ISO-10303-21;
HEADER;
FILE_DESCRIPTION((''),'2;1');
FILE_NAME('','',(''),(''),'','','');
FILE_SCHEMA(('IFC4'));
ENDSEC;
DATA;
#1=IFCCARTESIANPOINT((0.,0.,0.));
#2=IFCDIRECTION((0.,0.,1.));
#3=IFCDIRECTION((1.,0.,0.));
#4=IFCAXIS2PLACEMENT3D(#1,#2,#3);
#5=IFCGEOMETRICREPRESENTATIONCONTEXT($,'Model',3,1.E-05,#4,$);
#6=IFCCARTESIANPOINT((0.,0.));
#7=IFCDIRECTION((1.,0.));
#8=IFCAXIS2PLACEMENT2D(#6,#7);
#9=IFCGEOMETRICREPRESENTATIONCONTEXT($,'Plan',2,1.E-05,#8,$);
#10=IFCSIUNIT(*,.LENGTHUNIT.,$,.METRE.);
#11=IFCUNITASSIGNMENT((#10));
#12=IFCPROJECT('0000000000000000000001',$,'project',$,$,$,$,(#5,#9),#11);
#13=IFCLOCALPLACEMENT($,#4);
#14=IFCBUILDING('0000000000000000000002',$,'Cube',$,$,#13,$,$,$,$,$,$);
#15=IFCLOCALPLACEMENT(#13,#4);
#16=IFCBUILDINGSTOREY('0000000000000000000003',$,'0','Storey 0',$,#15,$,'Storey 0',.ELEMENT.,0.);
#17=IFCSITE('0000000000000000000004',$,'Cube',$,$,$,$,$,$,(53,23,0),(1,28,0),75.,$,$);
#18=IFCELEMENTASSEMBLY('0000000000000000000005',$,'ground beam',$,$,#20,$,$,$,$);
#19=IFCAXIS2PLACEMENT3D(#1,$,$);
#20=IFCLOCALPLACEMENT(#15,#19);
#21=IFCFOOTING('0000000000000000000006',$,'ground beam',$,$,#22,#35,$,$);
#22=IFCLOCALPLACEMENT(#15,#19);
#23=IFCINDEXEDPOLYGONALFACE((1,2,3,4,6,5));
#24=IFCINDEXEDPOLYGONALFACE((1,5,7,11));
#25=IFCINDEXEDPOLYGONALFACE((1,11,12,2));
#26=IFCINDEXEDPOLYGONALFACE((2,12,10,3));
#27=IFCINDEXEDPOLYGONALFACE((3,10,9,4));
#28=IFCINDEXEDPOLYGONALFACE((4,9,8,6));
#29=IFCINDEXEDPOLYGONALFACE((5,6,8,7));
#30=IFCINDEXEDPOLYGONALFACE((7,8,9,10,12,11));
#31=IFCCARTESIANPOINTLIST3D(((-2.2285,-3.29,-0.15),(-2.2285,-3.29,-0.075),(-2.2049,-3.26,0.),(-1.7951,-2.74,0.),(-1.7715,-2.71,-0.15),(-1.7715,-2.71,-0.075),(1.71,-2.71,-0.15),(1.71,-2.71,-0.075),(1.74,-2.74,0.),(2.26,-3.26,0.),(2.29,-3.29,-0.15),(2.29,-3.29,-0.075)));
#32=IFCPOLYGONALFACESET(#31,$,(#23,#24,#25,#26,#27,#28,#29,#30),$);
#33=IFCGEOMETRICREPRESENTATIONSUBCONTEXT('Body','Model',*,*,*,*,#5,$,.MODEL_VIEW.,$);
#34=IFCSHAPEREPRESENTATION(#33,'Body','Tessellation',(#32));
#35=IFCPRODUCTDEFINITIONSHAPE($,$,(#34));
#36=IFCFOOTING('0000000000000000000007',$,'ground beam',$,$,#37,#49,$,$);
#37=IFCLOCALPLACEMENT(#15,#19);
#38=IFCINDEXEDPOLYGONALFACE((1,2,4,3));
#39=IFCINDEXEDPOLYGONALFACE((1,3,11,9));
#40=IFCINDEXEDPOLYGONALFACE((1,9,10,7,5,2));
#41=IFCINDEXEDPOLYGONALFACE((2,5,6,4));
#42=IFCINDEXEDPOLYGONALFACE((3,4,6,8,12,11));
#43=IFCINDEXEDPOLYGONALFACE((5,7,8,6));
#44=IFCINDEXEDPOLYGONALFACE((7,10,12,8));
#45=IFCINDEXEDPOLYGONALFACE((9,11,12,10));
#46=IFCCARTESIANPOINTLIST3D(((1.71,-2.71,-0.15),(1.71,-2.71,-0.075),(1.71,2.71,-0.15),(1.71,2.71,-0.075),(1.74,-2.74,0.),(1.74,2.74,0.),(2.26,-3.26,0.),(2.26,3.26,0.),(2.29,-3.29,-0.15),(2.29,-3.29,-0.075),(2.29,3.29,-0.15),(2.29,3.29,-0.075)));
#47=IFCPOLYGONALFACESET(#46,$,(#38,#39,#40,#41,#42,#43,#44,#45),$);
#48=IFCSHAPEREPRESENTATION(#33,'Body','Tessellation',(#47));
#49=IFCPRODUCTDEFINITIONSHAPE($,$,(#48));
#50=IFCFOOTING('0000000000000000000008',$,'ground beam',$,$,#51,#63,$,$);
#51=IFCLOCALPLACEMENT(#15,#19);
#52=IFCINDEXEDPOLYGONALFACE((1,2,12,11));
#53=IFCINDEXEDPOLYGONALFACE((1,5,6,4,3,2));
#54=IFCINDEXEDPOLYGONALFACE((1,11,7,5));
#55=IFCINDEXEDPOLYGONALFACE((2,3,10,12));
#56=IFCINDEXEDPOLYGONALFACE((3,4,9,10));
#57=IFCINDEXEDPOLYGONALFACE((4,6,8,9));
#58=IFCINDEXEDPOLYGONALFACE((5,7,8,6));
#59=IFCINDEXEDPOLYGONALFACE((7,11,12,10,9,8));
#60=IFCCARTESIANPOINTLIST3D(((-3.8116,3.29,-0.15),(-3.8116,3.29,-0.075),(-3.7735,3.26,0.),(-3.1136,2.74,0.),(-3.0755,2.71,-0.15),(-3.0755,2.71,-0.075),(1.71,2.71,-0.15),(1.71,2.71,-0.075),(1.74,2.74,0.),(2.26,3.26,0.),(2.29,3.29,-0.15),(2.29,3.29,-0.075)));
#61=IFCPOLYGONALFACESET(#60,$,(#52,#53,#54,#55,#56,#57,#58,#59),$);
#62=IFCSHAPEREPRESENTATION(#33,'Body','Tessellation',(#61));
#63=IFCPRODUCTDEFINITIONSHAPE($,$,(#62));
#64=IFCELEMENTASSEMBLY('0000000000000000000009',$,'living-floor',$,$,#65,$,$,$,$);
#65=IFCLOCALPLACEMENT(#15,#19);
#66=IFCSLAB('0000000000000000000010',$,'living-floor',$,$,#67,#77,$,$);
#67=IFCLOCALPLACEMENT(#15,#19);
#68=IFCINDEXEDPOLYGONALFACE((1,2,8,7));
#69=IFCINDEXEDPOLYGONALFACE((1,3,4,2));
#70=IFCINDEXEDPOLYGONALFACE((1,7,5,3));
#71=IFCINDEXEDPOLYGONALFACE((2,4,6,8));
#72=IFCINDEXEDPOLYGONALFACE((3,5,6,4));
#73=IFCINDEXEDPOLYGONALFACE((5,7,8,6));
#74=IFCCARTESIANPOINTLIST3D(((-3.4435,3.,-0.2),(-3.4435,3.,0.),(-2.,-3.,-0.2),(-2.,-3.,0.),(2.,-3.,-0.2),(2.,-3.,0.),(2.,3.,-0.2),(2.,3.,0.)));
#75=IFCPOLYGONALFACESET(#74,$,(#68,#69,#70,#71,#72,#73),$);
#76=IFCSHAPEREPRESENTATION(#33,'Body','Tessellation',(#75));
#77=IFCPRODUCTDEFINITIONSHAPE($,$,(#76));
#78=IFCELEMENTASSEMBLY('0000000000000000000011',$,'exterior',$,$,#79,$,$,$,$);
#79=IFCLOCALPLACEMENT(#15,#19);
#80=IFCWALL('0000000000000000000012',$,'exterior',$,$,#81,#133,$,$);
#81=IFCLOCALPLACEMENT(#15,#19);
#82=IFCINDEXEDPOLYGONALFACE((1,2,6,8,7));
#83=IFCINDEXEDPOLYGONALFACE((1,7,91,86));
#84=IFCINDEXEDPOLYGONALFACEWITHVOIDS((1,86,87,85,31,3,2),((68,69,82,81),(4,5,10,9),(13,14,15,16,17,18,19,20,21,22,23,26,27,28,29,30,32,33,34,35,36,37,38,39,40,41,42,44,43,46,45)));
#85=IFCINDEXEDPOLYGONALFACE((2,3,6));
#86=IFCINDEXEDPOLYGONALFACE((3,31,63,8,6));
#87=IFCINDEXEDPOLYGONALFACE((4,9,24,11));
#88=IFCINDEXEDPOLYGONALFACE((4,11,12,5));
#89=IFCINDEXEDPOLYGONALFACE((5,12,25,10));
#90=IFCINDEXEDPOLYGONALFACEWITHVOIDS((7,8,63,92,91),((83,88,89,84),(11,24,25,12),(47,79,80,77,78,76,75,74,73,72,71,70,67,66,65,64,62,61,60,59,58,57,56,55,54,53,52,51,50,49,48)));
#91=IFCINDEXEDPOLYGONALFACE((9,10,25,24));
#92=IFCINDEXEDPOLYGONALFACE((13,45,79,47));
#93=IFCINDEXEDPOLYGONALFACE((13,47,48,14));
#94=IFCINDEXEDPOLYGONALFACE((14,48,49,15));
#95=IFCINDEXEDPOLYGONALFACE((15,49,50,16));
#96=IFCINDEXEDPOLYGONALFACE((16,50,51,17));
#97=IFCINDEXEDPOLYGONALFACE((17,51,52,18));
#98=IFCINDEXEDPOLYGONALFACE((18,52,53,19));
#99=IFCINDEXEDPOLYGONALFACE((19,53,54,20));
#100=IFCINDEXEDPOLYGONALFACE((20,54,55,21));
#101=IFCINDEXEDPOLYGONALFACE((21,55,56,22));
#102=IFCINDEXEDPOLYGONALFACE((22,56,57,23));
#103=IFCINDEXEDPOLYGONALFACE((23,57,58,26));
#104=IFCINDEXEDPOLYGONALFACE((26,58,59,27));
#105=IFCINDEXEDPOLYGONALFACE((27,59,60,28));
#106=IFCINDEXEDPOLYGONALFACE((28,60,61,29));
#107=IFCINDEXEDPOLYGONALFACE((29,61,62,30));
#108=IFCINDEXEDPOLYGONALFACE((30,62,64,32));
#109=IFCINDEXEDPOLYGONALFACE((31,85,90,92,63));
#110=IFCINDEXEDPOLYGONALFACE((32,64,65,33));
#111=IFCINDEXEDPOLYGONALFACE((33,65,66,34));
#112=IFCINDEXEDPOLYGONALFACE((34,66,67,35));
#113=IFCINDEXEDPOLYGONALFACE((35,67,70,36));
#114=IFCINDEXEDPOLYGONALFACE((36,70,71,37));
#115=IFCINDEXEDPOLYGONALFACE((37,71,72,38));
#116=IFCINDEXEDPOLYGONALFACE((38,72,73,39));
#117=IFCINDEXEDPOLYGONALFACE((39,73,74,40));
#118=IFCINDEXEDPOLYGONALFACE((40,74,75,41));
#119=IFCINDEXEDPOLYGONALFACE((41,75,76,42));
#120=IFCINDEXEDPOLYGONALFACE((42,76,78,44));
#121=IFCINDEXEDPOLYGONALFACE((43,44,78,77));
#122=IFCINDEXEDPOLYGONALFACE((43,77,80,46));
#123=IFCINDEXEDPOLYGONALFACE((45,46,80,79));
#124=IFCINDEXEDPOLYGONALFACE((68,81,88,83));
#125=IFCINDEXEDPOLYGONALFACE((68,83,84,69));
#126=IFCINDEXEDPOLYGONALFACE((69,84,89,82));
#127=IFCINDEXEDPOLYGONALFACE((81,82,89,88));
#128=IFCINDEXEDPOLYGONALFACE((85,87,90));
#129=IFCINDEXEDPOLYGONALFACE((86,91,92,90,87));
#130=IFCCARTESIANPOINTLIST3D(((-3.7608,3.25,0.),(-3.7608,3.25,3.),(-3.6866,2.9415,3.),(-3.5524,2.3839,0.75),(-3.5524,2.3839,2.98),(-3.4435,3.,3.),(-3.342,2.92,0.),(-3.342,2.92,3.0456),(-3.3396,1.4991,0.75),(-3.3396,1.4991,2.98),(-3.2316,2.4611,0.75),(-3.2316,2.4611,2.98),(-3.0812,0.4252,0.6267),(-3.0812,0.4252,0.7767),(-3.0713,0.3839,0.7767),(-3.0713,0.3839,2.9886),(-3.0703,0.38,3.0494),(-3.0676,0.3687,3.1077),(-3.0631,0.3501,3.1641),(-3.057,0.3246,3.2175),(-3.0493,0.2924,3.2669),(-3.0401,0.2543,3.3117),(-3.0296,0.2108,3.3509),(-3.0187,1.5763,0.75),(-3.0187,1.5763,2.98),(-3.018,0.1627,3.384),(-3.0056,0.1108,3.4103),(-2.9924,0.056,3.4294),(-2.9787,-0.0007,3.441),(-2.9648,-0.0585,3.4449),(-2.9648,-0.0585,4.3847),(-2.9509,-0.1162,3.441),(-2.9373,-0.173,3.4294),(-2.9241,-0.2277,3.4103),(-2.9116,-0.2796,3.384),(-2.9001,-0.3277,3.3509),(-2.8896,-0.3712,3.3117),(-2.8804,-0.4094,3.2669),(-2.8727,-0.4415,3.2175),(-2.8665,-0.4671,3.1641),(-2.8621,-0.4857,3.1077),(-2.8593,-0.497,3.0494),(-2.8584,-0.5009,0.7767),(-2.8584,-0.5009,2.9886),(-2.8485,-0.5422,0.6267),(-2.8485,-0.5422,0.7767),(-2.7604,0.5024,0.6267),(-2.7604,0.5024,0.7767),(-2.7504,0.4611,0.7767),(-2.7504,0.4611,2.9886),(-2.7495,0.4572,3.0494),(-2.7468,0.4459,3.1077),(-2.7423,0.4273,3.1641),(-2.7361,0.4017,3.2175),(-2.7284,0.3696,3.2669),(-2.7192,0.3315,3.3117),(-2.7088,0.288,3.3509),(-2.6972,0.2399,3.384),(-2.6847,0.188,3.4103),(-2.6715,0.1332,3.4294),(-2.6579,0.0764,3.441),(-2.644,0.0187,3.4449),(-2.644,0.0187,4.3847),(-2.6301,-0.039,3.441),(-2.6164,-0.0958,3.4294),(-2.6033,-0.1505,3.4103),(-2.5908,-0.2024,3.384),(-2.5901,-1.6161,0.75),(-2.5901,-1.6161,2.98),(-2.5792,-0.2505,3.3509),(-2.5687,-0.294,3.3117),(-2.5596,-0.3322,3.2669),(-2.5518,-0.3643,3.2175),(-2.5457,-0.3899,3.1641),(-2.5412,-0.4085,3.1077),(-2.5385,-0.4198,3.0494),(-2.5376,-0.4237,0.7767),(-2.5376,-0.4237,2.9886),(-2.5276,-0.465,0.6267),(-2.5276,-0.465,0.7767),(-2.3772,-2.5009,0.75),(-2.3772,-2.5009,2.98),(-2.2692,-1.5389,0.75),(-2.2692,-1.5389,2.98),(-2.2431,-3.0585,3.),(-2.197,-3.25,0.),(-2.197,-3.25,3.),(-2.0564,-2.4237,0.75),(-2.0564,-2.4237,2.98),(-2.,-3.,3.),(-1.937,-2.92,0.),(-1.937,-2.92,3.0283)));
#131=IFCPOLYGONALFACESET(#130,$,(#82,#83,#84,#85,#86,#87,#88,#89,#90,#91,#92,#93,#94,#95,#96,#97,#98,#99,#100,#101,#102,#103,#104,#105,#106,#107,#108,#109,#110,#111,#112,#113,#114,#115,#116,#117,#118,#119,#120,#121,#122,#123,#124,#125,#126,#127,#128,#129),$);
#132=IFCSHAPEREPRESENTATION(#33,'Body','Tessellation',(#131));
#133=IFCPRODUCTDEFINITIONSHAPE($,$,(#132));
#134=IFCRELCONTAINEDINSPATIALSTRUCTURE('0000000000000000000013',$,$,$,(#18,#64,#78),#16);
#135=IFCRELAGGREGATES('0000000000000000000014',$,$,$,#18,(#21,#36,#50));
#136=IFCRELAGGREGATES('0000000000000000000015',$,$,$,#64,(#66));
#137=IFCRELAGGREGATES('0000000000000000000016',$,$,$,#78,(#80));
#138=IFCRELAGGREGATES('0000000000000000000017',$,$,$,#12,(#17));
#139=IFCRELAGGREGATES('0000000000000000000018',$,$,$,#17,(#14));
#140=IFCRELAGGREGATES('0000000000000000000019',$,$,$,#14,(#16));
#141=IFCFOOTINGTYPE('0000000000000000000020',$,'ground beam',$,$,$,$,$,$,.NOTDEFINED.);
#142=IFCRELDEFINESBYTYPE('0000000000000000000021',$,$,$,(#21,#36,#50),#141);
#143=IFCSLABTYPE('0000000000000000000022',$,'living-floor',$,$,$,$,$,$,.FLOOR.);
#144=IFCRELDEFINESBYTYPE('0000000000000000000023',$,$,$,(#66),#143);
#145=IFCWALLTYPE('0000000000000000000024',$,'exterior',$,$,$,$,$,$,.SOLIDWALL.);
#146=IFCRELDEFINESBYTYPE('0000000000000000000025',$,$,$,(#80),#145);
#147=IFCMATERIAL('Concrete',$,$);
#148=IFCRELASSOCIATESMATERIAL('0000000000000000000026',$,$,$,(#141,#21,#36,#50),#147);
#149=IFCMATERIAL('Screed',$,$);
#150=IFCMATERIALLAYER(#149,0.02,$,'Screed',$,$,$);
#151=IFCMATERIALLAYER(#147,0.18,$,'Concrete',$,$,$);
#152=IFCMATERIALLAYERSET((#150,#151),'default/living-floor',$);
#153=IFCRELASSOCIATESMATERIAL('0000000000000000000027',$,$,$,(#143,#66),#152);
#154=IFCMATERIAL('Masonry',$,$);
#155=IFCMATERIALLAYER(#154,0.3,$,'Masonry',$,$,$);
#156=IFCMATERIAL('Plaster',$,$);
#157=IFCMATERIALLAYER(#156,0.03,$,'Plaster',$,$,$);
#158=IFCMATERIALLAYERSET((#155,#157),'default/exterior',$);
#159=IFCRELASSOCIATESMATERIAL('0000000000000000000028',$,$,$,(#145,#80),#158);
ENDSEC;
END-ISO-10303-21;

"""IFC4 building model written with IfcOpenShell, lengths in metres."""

from ifc_helpers import new_model, si_unit, frame, origin, origin_with_axes, origin_2d_with_axis, place, context, subcontext, project, spatial, polyline, outline, extrude, clip, halfspace, bounded_halfspace, material, layer, layer_set, layer_usage, material_profile, profile_set, profile_usage, type_object, element, aggregate, save


model = new_model("IFC4")

# Units and contexts
model_context = context("Model", 3, precision=1e-05, world=origin_with_axes())
plan_context = context("Plan", 2, precision=1e-05, world=origin_2d_with_axis())
body_context_1 = subcontext(model_context, "Body", "Model", "MODEL_VIEW")
ifc_project = project(units=[si_unit("LENGTHUNIT", "METRE")], contexts=[model_context, plan_context])

# Site, building, storey
site = spatial("IfcSite", under=ifc_project, Name="Cube", RefLatitude=(53, 23, 0), RefLongitude=(1, 28, 0), RefElevation=75.0)
building_placement = place(None, origin_with_axes())
building = spatial("IfcBuilding", under=site, at=building_placement, Name="Cube")
storey_placement = place(building_placement, origin_with_axes())
storey = spatial("IfcBuildingStorey", under=building, at=storey_placement, Name="0", Description="Storey 0", LongName="Storey 0", CompositionType="ELEMENT", Elevation=0.0)

# Element assembly, footings
assembly_1_placement = place(storey_placement, origin_with_axes())
assembly_1 = element("IfcElementAssembly", 1, at=assembly_1_placement, inside=storey, Name="ground beam")
ifc_material_1 = material(Name="Concrete")
ifc_material_profile = material_profile(ifc_material_1, outline(polyline([(-0.26, 0.0), (-0.29, -0.075), (-0.29, -0.15), (0.29, -0.15), (0.29, -0.075), (0.26, 0.0), (-0.26, 0.0)])))
ifc_profile_set = profile_set([ifc_material_profile])
ifc_profile_usage_1 = profile_usage(ifc_profile_set)
footing_type = type_object("IfcFootingType", Name="ground beam", PredefinedType="NOTDEFINED", material=ifc_profile_set)
footing_1_placement = place(assembly_1_placement, frame((3.0, -3.0, 0.0), z_axis=(-1.0, 0.0, 0.0), x_axis=(0.0, -1.0, 0.0)))
footing_1 = element("IfcFooting", 2, at=footing_1_placement, type_object=footing_type, material=ifc_profile_usage_1, Name="ground beam", context=body_context_1, shape_type="Clipping", body=[
    clip(clip(extrude(outline(polyline([(-0.26, 0.0), (-0.29, -0.075), (-0.29, -0.15), (0.29, -0.15), (0.29, -0.075), (0.26, 0.0), (-0.26, 0.0)])), origin_with_axes(), (0.0, 0.0, 1.0), 6.0), halfspace(frame((0.0, 0.0, 1.0), z_axis=(-0.707107, 0.0, -0.707107), x_axis=(0.0, 1.0, 0.0)), False)), halfspace(frame((0.0, 0.0, 5.0), z_axis=(-0.618904, 0.0, 0.785467), x_axis=(0.0, 1.0, 0.0)), False)),
])
ifc_profile_usage_2 = profile_usage(ifc_profile_set)
footing_2_placement = place(assembly_1_placement, frame((2.0, 4.0, 0.0), z_axis=(0.0, -1.0, 0.0), x_axis=(1.0, 0.0, 0.0)))
footing_2 = element("IfcFooting", 3, at=footing_2_placement, type_object=footing_type, material=ifc_profile_usage_2, Name="ground beam", context=body_context_1, shape_type="Clipping", body=[
    clip(clip(extrude(outline(polyline([(-0.26, 0.0), (-0.29, -0.075), (-0.29, -0.15), (0.29, -0.15), (0.29, -0.075), (0.26, 0.0), (-0.26, 0.0)])), origin_with_axes(), (0.0, 0.0, 1.0), 8.0), halfspace(frame((0.0, 0.0, 1.0), z_axis=(-0.707107, 0.0, -0.707107), x_axis=(0.0, 1.0, 0.0)), False)), halfspace(frame((0.0, 0.0, 7.0), z_axis=(-0.707107, 0.0, 0.707107), x_axis=(0.0, 1.0, 0.0)), False)),
])
ifc_profile_usage_3 = profile_usage(ifc_profile_set)
footing_3_placement = place(assembly_1_placement, frame((-4.4435, 3.0, 0.0), z_axis=(1.0, 0.0, 0.0), x_axis=(0.0, 1.0, 0.0)))
footing_3 = element("IfcFooting", 4, at=footing_3_placement, type_object=footing_type, material=ifc_profile_usage_3, Name="ground beam", context=body_context_1, shape_type="Clipping", body=[
    clip(clip(extrude(outline(polyline([(-0.26, 0.0), (-0.29, -0.075), (-0.29, -0.15), (0.29, -0.15), (0.29, -0.075), (0.26, 0.0), (-0.26, 0.0)])), origin_with_axes(), (0.0, 0.0, 1.0), 7.4435), halfspace(frame((0.0, 0.0, 1.0), z_axis=(-0.785467, 0.0, -0.618904), x_axis=(0.0, 1.0, 0.0)), False)), halfspace(frame((0.0, 0.0, 6.4435), z_axis=(-0.707107, 0.0, 0.707107), x_axis=(0.0, 1.0, 0.0)), False)),
])
aggregate(assembly_1, [footing_1, footing_2, footing_3])

# Element assembly, slab
assembly_2_placement = place(storey_placement, origin_with_axes())
assembly_2 = element("IfcElementAssembly", 5, at=assembly_2_placement, inside=storey, Name="living-floor")
ifc_material_2 = material(Name="Screed")
ifc_layer_1 = layer(ifc_material_2, 0.02, Name="Screed")
ifc_layer_2 = layer(ifc_material_1, 0.18, Name="Concrete")
ifc_layer_set_1 = layer_set([ifc_layer_1, ifc_layer_2], Name="default/living-floor")
ifc_layer_usage_1 = layer_usage(ifc_layer_set_1, "AXIS3", "POSITIVE", 0.0)
slab_type = type_object("IfcSlabType", Name="living-floor", PredefinedType="FLOOR", material=ifc_layer_set_1)
slab_placement = place(assembly_2_placement, frame((2.0, 3.0, -0.2), z_axis=(0.0, 0.0, -1.0), x_axis=(0.0, 1.0, 0.0)))
slab = element("IfcSlab", 6, at=slab_placement, type_object=slab_type, material=ifc_layer_usage_1, Name="living-floor", context=body_context_1, shape_type="SweptSolid", body=[
    extrude(outline(polyline([(0.0, 0.0), (-6.0, 0.0), (-6.0, -4.0), (0.0, -5.4435), (0.0, 0.0)])), origin(), (0.0, 0.0, -1.0), 0.2),
])
aggregate(assembly_2, [slab])

# Element assembly, wall, openings
assembly_3_placement = place(storey_placement, frame((-3.4435, 3.0, 0.0), z_axis=(0.0, 0.0, 1.0), x_axis=(0.233915, -0.972257, 0.0)))
assembly_3 = element("IfcElementAssembly", 7, at=assembly_3_placement, inside=storey, Name="exterior")
ifc_material_3 = material(Name="Masonry")
ifc_layer_3 = layer(ifc_material_3, 0.3, Name="Masonry")
ifc_material_4 = material(Name="Plaster")
ifc_layer_4 = layer(ifc_material_4, 0.03, Name="Plaster")
ifc_layer_set_2 = layer_set([ifc_layer_3, ifc_layer_4], Name="default/exterior")
ifc_layer_usage_2 = layer_usage(ifc_layer_set_2, "AXIS2", "POSITIVE", -0.25)
wall_type = type_object("IfcWallType", Name="exterior", PredefinedType="SOLIDWALL", material=ifc_layer_set_2)
wall_1_placement = place(assembly_3_placement, frame((0.0, 0.0, 0.0), z_axis=(0.0, 0.0, 1.0), x_axis=(1.0, 0.0, 0.0)))
wall_1 = element("IfcWall", 8, at=wall_1_placement, type_object=wall_type, material=ifc_layer_usage_2, Name="exterior", context=body_context_1, shape_type="Clipping", body=[
    clip(clip(clip(clip(extrude(outline(polyline([(0.1015, 0.08), (-0.3173, -0.25), (6.3682, -0.25), (6.1082, 0.08), (0.1015, 0.08)])), origin(), (0.0, 0.0, 1.0), 4.385), bounded_halfspace(frame((6.1712, 0.0, 3.0), z_axis=(0.409415, 0.0, 0.912348), x_axis=(0.0, -1.0, 0.0)), False, origin(), polyline([(6.1712, -1.0), (3.0856, -1.0), (3.0856, 1.0), (6.1712, 1.0), (6.1712, -1.0)]))), bounded_halfspace(frame((6.1712, 0.0, 3.0), z_axis=(0.0, 0.0, 1.0), x_axis=(0.0, 1.0, 0.0)), False, origin(), polyline([(6.1712, 1.0), (7.1712, 1.0), (7.1712, -1.0), (6.1712, -1.0), (6.1712, 1.0)]))), bounded_halfspace(frame((3.0856, 0.0, 4.3847), z_axis=(-0.409415, 0.0, 0.912348), x_axis=(0.0, -1.0, 0.0)), False, origin(), polyline([(3.0856, -1.0), (0.0, -1.0), (0.0, 1.0), (3.0856, 1.0), (3.0856, -1.0)]))), bounded_halfspace(frame((0.0, 0.0, 3.0), z_axis=(0.0, 0.0, 1.0), x_axis=(0.0, -1.0, 0.0)), False, origin(), polyline([(0.0, -1.0), (-1.0, -1.0), (-1.0, 1.0), (0.0, 1.0), (0.0, -1.0)]))),
])
opening_1_placement = place(wall_1_placement, frame((0.5735, -0.25, 0.75), z_axis=(0.0, 0.0, 1.0), x_axis=(1.0, 0.0, 0.0)))
element("IfcOpeningElement", 9, at=opening_1_placement, cuts=wall_1, PredefinedType="OPENING", context=body_context_1, shape_type="SweptSolid", body=[
    extrude(outline(polyline([(0.0, -0.02), (0.91, -0.02), (0.91, 0.35), (0.0, 0.35), (0.0, -0.02)])), origin(), (0.0, 0.0, 1.0), 2.23),
])
opening_2_placement = place(wall_1_placement, frame((2.6306, -0.25, 0.75), z_axis=(0.0, 0.0, 1.0), x_axis=(1.0, 0.0, 0.0)))
element("IfcOpeningElement", 10, at=opening_2_placement, cuts=wall_1, PredefinedType="OPENING", context=body_context_1, shape_type="SweptSolid", body=[
    extrude(outline(polyline([(0.1333, 2.5617), (0.1781, 2.6009), (0.2275, 2.634), (0.2809, 2.6603), (0.3373, 2.6794), (0.3956, 2.691), (0.455, 2.6949), (0.5144, 2.691), (0.5727, 2.6794), (0.6291, 2.6603), (0.6825, 2.634), (0.7319, 2.6009), (0.7767, 2.5617), (0.8159, 2.5169), (0.849, 2.4675), (0.8753, 2.4141), (0.8944, 2.3577), (0.906, 2.2994), (0.91, 2.2386), (0.91, 2.2069), (0.91, 0.0267), (0.9525, 0.0267), (0.9525, -0.1233), (-0.0425, -0.1233), (-0.0425, 0.0267), (0.0, 0.0267), (0.0, 2.2069), (0.0, 2.2386), (0.004, 2.2994), (0.0156, 2.3577), (0.0347, 2.4141), (0.061, 2.4675), (0.0941, 2.5169), (0.1333, 2.5617)])), frame((0.0, -0.02, 0.0), z_axis=(0.0, -1.0, 0.0), x_axis=(1.0, 0.0, 0.0)), (0.0, 0.0, -1.0), 0.37),
])
opening_3_placement = place(wall_1_placement, frame((4.6877, -0.25, 0.75), z_axis=(0.0, 0.0, 1.0), x_axis=(1.0, 0.0, 0.0)))
element("IfcOpeningElement", 11, at=opening_3_placement, cuts=wall_1, PredefinedType="OPENING", context=body_context_1, shape_type="SweptSolid", body=[
    extrude(outline(polyline([(0.0, -0.02), (0.91, -0.02), (0.91, 0.35), (0.0, 0.35), (0.0, -0.02)])), origin(), (0.0, 0.0, 1.0), 2.23),
])
aggregate(assembly_3, [wall_1])

save(model, "model.ifc")
